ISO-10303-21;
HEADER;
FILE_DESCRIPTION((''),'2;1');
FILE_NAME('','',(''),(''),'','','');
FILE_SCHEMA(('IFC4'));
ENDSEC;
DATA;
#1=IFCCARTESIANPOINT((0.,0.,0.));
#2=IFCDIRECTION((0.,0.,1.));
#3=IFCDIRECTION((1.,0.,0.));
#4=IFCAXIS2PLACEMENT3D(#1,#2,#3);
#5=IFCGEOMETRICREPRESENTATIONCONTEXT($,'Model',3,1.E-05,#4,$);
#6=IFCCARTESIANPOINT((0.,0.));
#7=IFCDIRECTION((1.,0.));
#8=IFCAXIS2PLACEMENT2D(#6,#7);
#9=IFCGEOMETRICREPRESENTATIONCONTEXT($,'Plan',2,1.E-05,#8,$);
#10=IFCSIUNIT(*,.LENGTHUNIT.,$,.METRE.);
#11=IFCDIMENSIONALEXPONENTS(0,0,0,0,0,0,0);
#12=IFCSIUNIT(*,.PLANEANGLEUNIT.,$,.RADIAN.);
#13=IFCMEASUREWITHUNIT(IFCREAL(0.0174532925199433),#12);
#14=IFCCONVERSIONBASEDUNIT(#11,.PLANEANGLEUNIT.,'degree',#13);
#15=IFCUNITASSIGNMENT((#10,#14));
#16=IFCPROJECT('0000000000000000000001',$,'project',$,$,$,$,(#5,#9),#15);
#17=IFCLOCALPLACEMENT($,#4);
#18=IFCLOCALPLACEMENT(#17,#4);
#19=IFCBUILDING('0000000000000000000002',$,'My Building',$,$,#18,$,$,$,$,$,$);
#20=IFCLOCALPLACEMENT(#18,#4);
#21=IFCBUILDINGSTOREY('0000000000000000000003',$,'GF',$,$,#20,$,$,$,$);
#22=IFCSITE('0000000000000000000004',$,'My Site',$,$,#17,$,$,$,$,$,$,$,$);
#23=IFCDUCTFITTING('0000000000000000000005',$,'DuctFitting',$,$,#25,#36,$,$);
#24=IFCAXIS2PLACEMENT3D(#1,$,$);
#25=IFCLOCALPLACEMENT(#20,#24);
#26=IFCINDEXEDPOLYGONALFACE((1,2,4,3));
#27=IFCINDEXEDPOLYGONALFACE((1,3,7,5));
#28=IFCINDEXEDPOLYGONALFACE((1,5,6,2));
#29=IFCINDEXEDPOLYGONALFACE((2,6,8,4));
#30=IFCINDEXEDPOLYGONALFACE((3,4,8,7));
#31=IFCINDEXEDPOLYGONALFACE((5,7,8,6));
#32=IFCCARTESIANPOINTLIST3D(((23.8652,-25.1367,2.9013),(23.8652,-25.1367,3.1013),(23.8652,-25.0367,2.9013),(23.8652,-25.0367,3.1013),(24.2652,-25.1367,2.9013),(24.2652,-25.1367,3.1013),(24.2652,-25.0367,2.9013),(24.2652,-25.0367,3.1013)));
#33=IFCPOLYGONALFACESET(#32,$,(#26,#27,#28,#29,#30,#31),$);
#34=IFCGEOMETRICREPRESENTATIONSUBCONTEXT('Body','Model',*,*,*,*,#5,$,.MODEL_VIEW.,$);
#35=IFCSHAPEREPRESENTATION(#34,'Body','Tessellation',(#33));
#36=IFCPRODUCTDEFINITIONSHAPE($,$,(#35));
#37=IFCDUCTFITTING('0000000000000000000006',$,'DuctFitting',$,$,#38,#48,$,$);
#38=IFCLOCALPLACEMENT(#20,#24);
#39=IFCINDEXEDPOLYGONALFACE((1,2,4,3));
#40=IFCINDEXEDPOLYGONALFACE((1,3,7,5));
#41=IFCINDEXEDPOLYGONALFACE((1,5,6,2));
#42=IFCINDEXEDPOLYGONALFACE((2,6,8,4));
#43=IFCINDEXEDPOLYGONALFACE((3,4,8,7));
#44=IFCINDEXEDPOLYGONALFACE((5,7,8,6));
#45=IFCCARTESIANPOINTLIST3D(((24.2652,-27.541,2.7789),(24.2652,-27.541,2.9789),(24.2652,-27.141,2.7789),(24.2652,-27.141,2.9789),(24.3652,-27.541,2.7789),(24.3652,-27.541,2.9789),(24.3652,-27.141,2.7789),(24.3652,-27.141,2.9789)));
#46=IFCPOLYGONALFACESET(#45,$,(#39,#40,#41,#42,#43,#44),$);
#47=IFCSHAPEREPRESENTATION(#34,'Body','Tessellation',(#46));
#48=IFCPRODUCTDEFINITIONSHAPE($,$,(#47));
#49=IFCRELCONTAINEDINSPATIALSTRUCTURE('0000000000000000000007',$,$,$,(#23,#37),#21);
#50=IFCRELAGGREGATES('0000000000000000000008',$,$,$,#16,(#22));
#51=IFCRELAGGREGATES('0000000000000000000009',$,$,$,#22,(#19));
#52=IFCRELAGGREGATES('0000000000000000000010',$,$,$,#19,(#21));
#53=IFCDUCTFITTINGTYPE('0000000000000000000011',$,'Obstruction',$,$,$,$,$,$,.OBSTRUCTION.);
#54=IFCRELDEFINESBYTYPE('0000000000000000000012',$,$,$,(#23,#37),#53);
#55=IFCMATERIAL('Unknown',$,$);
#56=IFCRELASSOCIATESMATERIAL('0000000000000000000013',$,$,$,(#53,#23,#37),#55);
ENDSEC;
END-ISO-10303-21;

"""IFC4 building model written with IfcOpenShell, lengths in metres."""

from ifc_helpers import new_model, entity, si_unit, converted_unit, frame, origin_with_axes, origin_2d_with_axis, place, context, subcontext, project, spatial, rectangle, extrude, material, material_profile, profile_set, profile_usage, type_object, element, save


model = new_model("IFC4")

# Units and contexts
model_context = context("Model", 3, precision=1e-05, world=origin_with_axes())
plan_context = context("Plan", 2, precision=1e-05, world=origin_2d_with_axis())
body_context_1 = subcontext(model_context, "Body", "Model", "MODEL_VIEW")
ifc_project = project(units=[si_unit("LENGTHUNIT", "METRE"), converted_unit("PLANEANGLEUNIT", "degree", entity("IfcReal", 0.0174532925199433), si_unit("PLANEANGLEUNIT", "RADIAN"), dimensions=[0, 0, 0, 0, 0, 0, 0])], contexts=[model_context, plan_context])

# Site, building, storey
site_placement = place(None, origin_with_axes())
site = spatial("IfcSite", under=ifc_project, at=site_placement, Name="My Site")
building_placement = place(site_placement, origin_with_axes())
building = spatial("IfcBuilding", under=site, at=building_placement, Name="My Building")
storey_placement = place(building_placement, origin_with_axes())
storey = spatial("IfcBuildingStorey", under=building, at=storey_placement, Name="GF")

# Shared definitions
ifc_material = material(Name="Unknown")

# Duct fittings
ifc_material_profile = material_profile(ifc_material, rectangle(XDim=0.4, YDim=0.2))
ifc_profile_set = profile_set([ifc_material_profile])
ifc_profile_usage_1 = profile_usage(ifc_profile_set, cardinal=5)
duct_fitting_type = type_object("IfcDuctFittingType", Name="Obstruction", PredefinedType="OBSTRUCTION", material=ifc_profile_set)
duct_fitting_1_placement = place(storey_placement, frame((24.0652, -25.0367, 3.0013), z_axis=(0.0, -1.0, 0.0), x_axis=(1.0, 0.0, 0.0)))
element("IfcDuctFitting", 1, at=duct_fitting_1_placement, inside=storey, type_object=duct_fitting_type, material=ifc_profile_usage_1, Name="DuctFitting", context=body_context_1, shape_type="SweptSolid", body=[
    extrude(rectangle(XDim=0.4, YDim=0.2), origin_with_axes(), (0.0, 0.0, 1.0), 0.1),
])
ifc_profile_usage_2 = profile_usage(ifc_profile_set, cardinal=5)
duct_fitting_2_placement = place(storey_placement, frame((24.2652, -27.341, 2.8789), z_axis=(1.0, -0.000001, 0.000001), x_axis=(0.000001, 1.0, 0.0)))
element("IfcDuctFitting", 2, at=duct_fitting_2_placement, inside=storey, type_object=duct_fitting_type, material=ifc_profile_usage_2, Name="DuctFitting", context=body_context_1, shape_type="SweptSolid", body=[
    extrude(rectangle(XDim=0.4, YDim=0.2), origin_with_axes(), (0.0, 0.0, 1.0), 0.1),
])

save(model, "model.ifc")
